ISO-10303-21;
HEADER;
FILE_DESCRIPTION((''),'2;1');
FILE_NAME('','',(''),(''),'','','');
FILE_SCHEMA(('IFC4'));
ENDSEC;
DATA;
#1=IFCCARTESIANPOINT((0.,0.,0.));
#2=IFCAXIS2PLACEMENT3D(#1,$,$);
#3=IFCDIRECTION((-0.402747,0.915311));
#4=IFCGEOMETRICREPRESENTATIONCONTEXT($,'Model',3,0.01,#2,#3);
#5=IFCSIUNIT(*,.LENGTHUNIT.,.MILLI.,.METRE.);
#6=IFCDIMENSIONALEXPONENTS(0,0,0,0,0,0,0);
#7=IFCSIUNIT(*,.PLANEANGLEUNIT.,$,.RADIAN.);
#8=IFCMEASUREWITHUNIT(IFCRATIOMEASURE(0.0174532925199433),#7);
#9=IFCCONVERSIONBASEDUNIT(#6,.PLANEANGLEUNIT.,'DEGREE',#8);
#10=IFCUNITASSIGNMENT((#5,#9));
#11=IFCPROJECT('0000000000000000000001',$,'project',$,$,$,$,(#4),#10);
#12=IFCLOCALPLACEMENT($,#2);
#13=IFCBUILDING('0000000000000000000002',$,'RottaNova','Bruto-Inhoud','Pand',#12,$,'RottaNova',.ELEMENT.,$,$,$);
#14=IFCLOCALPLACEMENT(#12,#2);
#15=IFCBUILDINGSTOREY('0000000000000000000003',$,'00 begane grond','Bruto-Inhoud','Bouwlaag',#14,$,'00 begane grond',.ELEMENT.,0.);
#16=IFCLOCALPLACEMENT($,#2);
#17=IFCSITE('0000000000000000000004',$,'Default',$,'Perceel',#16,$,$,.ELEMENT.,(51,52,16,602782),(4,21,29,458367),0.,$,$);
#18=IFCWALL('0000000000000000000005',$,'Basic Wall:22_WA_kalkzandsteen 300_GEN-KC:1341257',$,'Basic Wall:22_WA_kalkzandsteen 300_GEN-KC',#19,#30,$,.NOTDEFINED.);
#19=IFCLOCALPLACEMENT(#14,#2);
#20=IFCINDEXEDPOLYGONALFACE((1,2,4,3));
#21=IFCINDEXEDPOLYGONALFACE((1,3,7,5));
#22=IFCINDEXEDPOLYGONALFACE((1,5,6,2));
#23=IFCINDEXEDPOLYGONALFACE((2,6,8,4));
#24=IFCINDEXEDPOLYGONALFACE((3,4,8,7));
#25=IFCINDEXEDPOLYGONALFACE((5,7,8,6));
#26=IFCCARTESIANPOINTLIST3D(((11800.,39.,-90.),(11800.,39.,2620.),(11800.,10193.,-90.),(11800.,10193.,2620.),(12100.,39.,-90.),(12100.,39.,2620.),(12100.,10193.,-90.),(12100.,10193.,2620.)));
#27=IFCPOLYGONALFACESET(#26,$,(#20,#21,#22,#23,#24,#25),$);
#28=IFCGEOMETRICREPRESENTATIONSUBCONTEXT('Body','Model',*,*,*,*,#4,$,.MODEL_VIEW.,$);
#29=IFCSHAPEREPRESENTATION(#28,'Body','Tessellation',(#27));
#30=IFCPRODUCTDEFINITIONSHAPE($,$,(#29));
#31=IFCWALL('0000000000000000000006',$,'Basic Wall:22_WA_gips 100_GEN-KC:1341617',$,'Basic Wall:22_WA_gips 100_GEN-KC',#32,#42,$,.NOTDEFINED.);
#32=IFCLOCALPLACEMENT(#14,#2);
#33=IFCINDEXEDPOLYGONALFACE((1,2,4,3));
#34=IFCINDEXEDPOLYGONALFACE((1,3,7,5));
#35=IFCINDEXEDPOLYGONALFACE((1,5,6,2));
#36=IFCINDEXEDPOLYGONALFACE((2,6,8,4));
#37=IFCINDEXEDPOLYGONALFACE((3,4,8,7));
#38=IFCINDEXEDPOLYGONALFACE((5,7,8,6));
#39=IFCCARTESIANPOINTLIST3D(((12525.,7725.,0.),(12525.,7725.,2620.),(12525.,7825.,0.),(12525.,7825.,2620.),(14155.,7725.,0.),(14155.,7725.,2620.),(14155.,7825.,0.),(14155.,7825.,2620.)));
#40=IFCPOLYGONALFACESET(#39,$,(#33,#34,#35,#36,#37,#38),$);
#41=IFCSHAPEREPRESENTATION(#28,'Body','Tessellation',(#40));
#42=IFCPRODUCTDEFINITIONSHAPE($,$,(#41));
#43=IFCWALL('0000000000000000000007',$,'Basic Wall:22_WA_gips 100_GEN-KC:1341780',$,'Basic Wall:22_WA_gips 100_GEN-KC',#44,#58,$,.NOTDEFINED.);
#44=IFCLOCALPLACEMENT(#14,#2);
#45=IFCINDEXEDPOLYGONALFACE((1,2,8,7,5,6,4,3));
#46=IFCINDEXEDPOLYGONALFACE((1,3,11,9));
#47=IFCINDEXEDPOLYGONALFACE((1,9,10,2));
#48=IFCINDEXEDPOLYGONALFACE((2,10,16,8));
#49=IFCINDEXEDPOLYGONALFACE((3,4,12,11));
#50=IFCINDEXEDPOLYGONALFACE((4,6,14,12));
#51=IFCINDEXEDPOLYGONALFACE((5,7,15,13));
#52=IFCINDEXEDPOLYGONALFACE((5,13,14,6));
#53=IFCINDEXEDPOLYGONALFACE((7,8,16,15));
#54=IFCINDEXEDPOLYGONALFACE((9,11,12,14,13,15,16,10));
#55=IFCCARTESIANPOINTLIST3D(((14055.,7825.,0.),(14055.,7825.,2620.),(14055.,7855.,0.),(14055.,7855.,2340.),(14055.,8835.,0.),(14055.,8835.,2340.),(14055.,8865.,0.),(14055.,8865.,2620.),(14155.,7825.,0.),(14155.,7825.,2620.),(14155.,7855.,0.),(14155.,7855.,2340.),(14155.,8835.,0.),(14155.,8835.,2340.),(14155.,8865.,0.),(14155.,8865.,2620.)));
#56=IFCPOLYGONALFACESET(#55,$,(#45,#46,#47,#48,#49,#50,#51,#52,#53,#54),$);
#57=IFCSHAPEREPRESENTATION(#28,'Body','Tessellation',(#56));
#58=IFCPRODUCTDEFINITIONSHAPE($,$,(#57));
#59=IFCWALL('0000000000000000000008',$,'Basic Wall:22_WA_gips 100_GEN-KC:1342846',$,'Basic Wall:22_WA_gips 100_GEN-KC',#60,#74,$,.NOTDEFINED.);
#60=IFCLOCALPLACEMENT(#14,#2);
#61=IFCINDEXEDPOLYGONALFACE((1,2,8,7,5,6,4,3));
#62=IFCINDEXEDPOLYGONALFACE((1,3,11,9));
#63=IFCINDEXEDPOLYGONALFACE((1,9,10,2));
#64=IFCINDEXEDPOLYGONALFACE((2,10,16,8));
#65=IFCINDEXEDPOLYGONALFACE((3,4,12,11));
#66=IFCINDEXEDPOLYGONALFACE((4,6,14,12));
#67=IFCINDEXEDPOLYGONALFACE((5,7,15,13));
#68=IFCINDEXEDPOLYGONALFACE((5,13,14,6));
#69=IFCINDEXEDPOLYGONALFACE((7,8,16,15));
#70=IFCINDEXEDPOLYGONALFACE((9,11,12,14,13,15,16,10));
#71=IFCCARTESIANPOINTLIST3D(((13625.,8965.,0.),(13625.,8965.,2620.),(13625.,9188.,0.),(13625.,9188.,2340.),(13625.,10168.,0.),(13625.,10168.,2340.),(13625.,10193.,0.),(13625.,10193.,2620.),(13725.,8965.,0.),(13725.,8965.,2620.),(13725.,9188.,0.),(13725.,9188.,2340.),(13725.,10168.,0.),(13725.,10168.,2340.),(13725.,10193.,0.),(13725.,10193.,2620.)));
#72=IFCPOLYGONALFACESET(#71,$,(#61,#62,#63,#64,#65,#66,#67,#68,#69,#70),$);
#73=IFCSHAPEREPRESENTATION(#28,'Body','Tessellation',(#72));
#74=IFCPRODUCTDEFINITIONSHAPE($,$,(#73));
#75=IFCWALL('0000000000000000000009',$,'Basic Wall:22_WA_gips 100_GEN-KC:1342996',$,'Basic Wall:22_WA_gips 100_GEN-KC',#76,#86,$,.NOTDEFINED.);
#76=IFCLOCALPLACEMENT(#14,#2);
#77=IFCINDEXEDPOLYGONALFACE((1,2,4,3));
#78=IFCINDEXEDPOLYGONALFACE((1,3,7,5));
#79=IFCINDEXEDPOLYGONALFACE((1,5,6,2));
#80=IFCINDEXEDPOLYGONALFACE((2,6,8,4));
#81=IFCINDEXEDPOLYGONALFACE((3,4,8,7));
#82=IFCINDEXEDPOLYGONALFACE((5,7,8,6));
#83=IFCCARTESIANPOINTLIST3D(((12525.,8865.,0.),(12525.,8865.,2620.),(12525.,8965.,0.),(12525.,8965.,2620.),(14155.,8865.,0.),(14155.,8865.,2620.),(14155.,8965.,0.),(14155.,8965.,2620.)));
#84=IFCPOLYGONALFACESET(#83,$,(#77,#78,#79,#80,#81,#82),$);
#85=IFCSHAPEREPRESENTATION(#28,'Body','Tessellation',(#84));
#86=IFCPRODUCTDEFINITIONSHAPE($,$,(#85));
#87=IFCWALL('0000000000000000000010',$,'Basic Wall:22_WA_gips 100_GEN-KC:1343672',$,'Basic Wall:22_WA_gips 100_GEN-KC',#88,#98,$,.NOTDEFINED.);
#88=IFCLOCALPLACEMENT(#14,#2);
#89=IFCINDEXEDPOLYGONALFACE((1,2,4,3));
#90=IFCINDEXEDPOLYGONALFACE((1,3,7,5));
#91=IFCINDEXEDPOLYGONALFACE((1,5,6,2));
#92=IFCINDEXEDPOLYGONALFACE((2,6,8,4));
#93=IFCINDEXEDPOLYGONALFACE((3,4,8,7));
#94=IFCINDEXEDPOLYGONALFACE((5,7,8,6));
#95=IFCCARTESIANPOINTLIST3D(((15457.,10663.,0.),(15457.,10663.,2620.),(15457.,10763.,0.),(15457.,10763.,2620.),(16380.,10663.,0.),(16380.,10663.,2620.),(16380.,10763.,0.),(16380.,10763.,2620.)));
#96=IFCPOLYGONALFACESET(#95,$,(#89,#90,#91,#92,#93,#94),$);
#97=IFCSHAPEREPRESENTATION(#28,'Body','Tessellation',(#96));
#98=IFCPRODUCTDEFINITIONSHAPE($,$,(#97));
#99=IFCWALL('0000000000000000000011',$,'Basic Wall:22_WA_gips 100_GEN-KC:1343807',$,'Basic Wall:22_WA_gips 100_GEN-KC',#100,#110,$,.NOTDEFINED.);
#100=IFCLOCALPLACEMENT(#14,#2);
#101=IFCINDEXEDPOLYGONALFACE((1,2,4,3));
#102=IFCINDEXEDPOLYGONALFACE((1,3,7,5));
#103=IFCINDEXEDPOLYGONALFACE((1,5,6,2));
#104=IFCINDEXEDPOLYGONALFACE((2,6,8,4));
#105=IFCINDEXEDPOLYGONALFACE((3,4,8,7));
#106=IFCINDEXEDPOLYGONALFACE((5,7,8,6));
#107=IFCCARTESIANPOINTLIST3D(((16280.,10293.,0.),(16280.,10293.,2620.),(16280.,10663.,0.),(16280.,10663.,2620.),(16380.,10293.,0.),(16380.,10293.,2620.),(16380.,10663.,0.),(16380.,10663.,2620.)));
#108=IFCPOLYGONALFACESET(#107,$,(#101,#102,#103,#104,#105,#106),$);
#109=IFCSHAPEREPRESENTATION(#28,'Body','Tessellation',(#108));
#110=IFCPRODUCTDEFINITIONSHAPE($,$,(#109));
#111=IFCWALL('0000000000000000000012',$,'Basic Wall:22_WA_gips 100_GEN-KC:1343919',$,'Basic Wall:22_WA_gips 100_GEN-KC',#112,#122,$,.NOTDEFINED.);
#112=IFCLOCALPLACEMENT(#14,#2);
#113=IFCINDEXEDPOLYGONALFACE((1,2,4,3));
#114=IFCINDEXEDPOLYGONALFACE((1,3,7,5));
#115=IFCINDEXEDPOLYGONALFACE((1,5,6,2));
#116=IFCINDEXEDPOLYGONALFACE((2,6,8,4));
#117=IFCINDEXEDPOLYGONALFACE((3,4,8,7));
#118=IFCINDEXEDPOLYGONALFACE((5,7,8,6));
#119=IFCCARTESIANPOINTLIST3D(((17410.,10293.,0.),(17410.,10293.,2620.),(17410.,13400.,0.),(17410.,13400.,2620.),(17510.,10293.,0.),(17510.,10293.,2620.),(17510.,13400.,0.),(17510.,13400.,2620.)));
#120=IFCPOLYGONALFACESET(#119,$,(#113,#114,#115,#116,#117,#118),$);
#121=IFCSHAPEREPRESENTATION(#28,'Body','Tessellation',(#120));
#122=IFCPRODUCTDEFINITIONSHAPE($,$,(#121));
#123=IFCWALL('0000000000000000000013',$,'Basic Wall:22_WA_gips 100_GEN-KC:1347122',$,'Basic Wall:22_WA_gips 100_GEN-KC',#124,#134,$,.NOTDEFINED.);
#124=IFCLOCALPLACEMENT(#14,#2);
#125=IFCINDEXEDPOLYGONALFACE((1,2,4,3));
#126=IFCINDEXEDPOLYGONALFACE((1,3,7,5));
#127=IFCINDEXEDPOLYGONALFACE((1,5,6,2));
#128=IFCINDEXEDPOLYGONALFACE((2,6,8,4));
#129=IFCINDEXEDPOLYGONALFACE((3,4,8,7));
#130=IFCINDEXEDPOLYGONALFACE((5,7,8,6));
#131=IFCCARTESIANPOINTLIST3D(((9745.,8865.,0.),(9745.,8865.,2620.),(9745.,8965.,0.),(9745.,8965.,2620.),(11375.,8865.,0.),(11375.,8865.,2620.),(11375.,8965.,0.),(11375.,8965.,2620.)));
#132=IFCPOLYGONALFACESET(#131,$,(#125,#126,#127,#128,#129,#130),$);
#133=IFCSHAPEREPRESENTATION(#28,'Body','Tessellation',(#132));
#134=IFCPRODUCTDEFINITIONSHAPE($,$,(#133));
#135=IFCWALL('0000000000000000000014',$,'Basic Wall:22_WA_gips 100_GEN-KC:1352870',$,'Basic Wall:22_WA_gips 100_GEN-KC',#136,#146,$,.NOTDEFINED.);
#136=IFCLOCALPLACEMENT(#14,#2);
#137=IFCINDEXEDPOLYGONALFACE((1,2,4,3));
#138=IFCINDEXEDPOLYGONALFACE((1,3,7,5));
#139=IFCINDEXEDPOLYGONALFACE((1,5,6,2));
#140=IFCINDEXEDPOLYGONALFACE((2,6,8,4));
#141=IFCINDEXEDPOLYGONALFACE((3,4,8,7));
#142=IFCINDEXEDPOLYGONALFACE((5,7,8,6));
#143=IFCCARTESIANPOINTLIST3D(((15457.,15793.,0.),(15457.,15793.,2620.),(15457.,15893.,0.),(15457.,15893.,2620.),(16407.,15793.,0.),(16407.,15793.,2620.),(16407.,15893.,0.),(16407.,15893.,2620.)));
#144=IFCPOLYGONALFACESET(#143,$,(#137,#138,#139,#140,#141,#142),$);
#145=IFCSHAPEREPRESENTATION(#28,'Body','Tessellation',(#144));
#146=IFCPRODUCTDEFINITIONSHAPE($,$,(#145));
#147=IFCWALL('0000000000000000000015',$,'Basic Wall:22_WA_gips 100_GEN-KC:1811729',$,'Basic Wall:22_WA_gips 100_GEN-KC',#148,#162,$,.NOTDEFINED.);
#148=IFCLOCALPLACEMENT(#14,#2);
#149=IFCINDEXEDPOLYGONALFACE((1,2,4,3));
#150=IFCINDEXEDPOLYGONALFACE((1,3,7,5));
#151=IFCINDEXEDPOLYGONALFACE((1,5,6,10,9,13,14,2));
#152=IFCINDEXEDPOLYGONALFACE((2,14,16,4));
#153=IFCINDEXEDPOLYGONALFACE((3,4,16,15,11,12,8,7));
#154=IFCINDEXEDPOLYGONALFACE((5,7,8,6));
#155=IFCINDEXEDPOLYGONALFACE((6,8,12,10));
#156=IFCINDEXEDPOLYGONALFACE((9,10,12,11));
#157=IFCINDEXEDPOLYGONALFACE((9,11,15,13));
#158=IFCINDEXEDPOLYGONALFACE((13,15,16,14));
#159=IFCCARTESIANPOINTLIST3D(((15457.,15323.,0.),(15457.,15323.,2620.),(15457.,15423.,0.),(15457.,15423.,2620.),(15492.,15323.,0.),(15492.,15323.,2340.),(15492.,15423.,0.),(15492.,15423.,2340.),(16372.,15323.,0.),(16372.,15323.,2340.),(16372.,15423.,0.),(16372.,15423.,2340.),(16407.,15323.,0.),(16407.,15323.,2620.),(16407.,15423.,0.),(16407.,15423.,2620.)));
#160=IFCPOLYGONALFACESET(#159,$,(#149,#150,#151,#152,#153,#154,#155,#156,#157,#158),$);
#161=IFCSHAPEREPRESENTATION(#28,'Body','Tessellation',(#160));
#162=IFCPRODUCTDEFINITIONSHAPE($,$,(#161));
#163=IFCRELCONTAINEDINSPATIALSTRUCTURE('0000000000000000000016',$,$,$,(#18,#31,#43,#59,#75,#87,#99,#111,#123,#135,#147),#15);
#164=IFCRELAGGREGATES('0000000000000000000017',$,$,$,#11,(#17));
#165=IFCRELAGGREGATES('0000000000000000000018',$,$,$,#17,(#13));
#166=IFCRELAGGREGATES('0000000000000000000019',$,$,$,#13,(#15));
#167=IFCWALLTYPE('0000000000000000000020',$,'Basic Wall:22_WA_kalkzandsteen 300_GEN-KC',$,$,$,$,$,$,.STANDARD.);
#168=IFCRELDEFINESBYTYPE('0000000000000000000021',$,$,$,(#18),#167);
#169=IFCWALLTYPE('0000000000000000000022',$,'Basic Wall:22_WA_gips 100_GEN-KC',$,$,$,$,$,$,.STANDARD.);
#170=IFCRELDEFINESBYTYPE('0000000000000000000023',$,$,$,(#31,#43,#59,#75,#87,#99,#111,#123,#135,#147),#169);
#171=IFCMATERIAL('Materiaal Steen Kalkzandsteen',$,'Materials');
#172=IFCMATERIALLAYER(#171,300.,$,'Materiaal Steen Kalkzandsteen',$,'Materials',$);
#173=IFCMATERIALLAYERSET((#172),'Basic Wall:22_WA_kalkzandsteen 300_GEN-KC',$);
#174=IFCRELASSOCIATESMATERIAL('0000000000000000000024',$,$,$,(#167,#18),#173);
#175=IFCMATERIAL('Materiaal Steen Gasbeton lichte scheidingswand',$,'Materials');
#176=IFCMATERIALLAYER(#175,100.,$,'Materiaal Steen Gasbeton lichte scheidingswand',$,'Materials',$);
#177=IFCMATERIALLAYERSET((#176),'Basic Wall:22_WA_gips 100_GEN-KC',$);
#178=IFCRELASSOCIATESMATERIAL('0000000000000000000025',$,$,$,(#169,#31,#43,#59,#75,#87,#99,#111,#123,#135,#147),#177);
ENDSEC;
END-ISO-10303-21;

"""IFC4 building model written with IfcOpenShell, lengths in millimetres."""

from ifc_helpers import new_model, entity, si_unit, converted_unit, direction, frame, frame_2d, origin, place, context, subcontext, project, spatial, rectangle, extrude, material, layer, layer_set, type_object, element, save


model = new_model("IFC4")

# Units and contexts
model_context = context("Model", 3, precision=0.01, world=origin(), true_north=direction((-0.402747, 0.915311)))
body_context = subcontext(model_context, "Body", "Model", "MODEL_VIEW")
ifc_project = project(units=[si_unit("LENGTHUNIT", "METRE", prefix="MILLI"), converted_unit("PLANEANGLEUNIT", "DEGREE", entity("IfcRatioMeasure", 0.0174532925199433), si_unit("PLANEANGLEUNIT", "RADIAN"), dimensions=[0, 0, 0, 0, 0, 0, 0])], contexts=[model_context])

# Site, building, storey
site_placement = place(None, origin())
site = spatial("IfcSite", under=ifc_project, at=site_placement, Name="Default", ObjectType="Perceel", CompositionType="ELEMENT", RefLatitude=(51, 52, 16, 602782), RefLongitude=(4, 21, 29, 458367), RefElevation=0.0)
building_placement = place(None, origin())
building = spatial("IfcBuilding", under=site, at=building_placement, Name="RottaNova", Description="Bruto-Inhoud", ObjectType="Pand", LongName="RottaNova", CompositionType="ELEMENT")
storey_placement = place(building_placement, origin())
storey = spatial("IfcBuildingStorey", under=building, at=storey_placement, Name="00 begane grond", Description="Bruto-Inhoud", ObjectType="Bouwlaag", LongName="00 begane grond", CompositionType="ELEMENT", Elevation=0.0)

# Walls
ifc_material_1 = material(Name="Materiaal Steen Kalkzandsteen", Category="Materials")
ifc_layer_1 = layer(ifc_material_1, 300.0, Name="Materiaal Steen Kalkzandsteen", Category="Materials")
ifc_layer_set_1 = layer_set([ifc_layer_1], Name="Basic Wall:22_WA_kalkzandsteen 300_GEN-KC")
wall_type_1 = type_object("IfcWallType", Name="Basic Wall:22_WA_kalkzandsteen 300_GEN-KC", PredefinedType="STANDARD", material=ifc_layer_set_1)
wall_1_placement = place(storey_placement, frame((11950.0, 39.0, -90.0), z_axis=(0.0, 0.0, 1.0), x_axis=(0.0, 1.0, 0.0)))
element("IfcWall", 1, at=wall_1_placement, inside=storey, type_object=wall_type_1, material=ifc_layer_set_1, Name="Basic Wall:22_WA_kalkzandsteen 300_GEN-KC:1341257", ObjectType="Basic Wall:22_WA_kalkzandsteen 300_GEN-KC", PredefinedType="NOTDEFINED", context=body_context, shape_type="SweptSolid", body=[
    extrude(rectangle(XDim=10154.0, YDim=300.0, at=frame_2d((5077.0, 0.0), x_axis=(-1.0, 0.0))), origin(), (0.0, 0.0, 1.0), 2710.0),
])
ifc_material_2 = material(Name="Materiaal Steen Gasbeton lichte scheidingswand", Category="Materials")
ifc_layer_2 = layer(ifc_material_2, 100.0, Name="Materiaal Steen Gasbeton lichte scheidingswand", Category="Materials")
ifc_layer_set_2 = layer_set([ifc_layer_2], Name="Basic Wall:22_WA_gips 100_GEN-KC")
wall_type_2 = type_object("IfcWallType", Name="Basic Wall:22_WA_gips 100_GEN-KC", PredefinedType="STANDARD", material=ifc_layer_set_2)
wall_2_placement = place(storey_placement, frame((14155.0, 7775.0, 0.0), z_axis=(0.0, 0.0, 1.0), x_axis=(-1.0, 0.0, 0.0)))
element("IfcWall", 2, at=wall_2_placement, inside=storey, type_object=wall_type_2, material=ifc_layer_set_2, Name="Basic Wall:22_WA_gips 100_GEN-KC:1341617", ObjectType="Basic Wall:22_WA_gips 100_GEN-KC", PredefinedType="NOTDEFINED", context=body_context, shape_type="SweptSolid", body=[
    extrude(rectangle(XDim=1630.0, YDim=100.0, at=frame_2d((815.0, 0.0), x_axis=(-1.0, 0.0))), origin(), (0.0, 0.0, 1.0), 2620.0),
])

# Walls, openings
wall_3_placement = place(storey_placement, frame((14105.0, 8865.0, 0.0), z_axis=(0.0, 0.0, 1.0), x_axis=(0.0, -1.0, 0.0)))
wall_3 = element("IfcWall", 3, at=wall_3_placement, inside=storey, type_object=wall_type_2, material=ifc_layer_set_2, Name="Basic Wall:22_WA_gips 100_GEN-KC:1341780", ObjectType="Basic Wall:22_WA_gips 100_GEN-KC", PredefinedType="NOTDEFINED", context=body_context, shape_type="SweptSolid", body=[
    extrude(rectangle(XDim=1040.0, YDim=100.0, at=frame_2d((520.0, 0.0), x_axis=(-1.0, 0.0))), origin(), (0.0, 0.0, 1.0), 2620.0),
])
opening_1_placement = place(wall_3_placement, frame((30.0, -50.0, -90.0)))
element("IfcOpeningElement", 4, at=opening_1_placement, cuts=wall_3, PredefinedType="OPENING", context=body_context, shape_type="SweptSolid", body=[
    extrude(rectangle(XDim=2430.0, YDim=980.0, at=frame_2d((1215.0, 490.0), x_axis=(1.0, 0.0))), frame((0.0, 0.0, 0.0), z_axis=(0.0, 1.0, 0.0), x_axis=(0.0, 0.0, 1.0)), (0.0, 0.0, 1.0), 100.0),
])
wall_4_placement = place(storey_placement, frame((13675.0, 8965.0, 0.0), z_axis=(0.0, 0.0, 1.0), x_axis=(0.0, 1.0, 0.0)))
wall_4 = element("IfcWall", 5, at=wall_4_placement, inside=storey, type_object=wall_type_2, material=ifc_layer_set_2, Name="Basic Wall:22_WA_gips 100_GEN-KC:1342846", ObjectType="Basic Wall:22_WA_gips 100_GEN-KC", PredefinedType="NOTDEFINED", context=body_context, shape_type="SweptSolid", body=[
    extrude(rectangle(XDim=1228.0, YDim=100.0, at=frame_2d((614.0, 0.0), x_axis=(1.0, 0.0))), origin(), (0.0, 0.0, 1.0), 2620.0),
])
opening_2_placement = place(wall_4_placement, frame((1203.0, 50.0, -90.0)))
element("IfcOpeningElement", 6, at=opening_2_placement, cuts=wall_4, PredefinedType="OPENING", context=body_context, shape_type="SweptSolid", body=[
    extrude(rectangle(XDim=2430.0, YDim=980.0, at=frame_2d((1215.0, 490.0), x_axis=(1.0, 0.0))), frame((0.0, 0.0, 0.0), z_axis=(0.0, -1.0, 0.0), x_axis=(0.0, 0.0, 1.0)), (0.0, 0.0, 1.0), 100.0),
])

# Walls
wall_5_placement = place(storey_placement, frame((12525.0, 8915.0, 0.0)))
element("IfcWall", 7, at=wall_5_placement, inside=storey, type_object=wall_type_2, material=ifc_layer_set_2, Name="Basic Wall:22_WA_gips 100_GEN-KC:1342996", ObjectType="Basic Wall:22_WA_gips 100_GEN-KC", PredefinedType="NOTDEFINED", context=body_context, shape_type="SweptSolid", body=[
    extrude(rectangle(XDim=1630.0, YDim=100.0, at=frame_2d((815.0, 0.0), x_axis=(-1.0, 0.0))), origin(), (0.0, 0.0, 1.0), 2620.0),
])
wall_6_placement = place(storey_placement, frame((16380.0, 10713.0, 0.0), z_axis=(0.0, 0.0, 1.0), x_axis=(-1.0, 0.0, 0.0)))
element("IfcWall", 8, at=wall_6_placement, inside=storey, type_object=wall_type_2, material=ifc_layer_set_2, Name="Basic Wall:22_WA_gips 100_GEN-KC:1343672", ObjectType="Basic Wall:22_WA_gips 100_GEN-KC", PredefinedType="NOTDEFINED", context=body_context, shape_type="SweptSolid", body=[
    extrude(rectangle(XDim=923.0, YDim=100.0, at=frame_2d((461.5, 0.0), x_axis=(-1.0, 0.0))), origin(), (0.0, 0.0, 1.0), 2620.0),
])
wall_7_placement = place(storey_placement, frame((16330.0, 10663.0, 0.0), z_axis=(0.0, 0.0, 1.0), x_axis=(0.0, -1.0, 0.0)))
element("IfcWall", 9, at=wall_7_placement, inside=storey, type_object=wall_type_2, material=ifc_layer_set_2, Name="Basic Wall:22_WA_gips 100_GEN-KC:1343807", ObjectType="Basic Wall:22_WA_gips 100_GEN-KC", PredefinedType="NOTDEFINED", context=body_context, shape_type="SweptSolid", body=[
    extrude(rectangle(XDim=370.0, YDim=100.0, at=frame_2d((185.0, 0.0), x_axis=(-1.0, 0.0))), origin(), (0.0, 0.0, 1.0), 2620.0),
])
wall_8_placement = place(storey_placement, frame((17460.0, 13400.0, 0.0), z_axis=(0.0, 0.0, 1.0), x_axis=(0.0, -1.0, 0.0)))
element("IfcWall", 10, at=wall_8_placement, inside=storey, type_object=wall_type_2, material=ifc_layer_set_2, Name="Basic Wall:22_WA_gips 100_GEN-KC:1343919", ObjectType="Basic Wall:22_WA_gips 100_GEN-KC", PredefinedType="NOTDEFINED", context=body_context, shape_type="SweptSolid", body=[
    extrude(rectangle(XDim=3107.0, YDim=100.0, at=frame_2d((1553.5, 0.0), x_axis=(-1.0, 0.0))), origin(), (0.0, 0.0, 1.0), 2620.0),
])
wall_9_placement = place(storey_placement, frame((11375.0, 8915.0, 0.0), z_axis=(0.0, 0.0, 1.0), x_axis=(-1.0, 0.0, 0.0)))
element("IfcWall", 11, at=wall_9_placement, inside=storey, type_object=wall_type_2, material=ifc_layer_set_2, Name="Basic Wall:22_WA_gips 100_GEN-KC:1347122", ObjectType="Basic Wall:22_WA_gips 100_GEN-KC", PredefinedType="NOTDEFINED", context=body_context, shape_type="SweptSolid", body=[
    extrude(rectangle(XDim=1630.0, YDim=100.0, at=frame_2d((815.0, 0.0), x_axis=(-1.0, 0.0))), origin(), (0.0, 0.0, 1.0), 2620.0),
])
wall_10_placement = place(storey_placement, frame((16407.0, 15843.0, 0.0), z_axis=(0.0, 0.0, 1.0), x_axis=(-1.0, 0.0, 0.0)))
element("IfcWall", 12, at=wall_10_placement, inside=storey, type_object=wall_type_2, material=ifc_layer_set_2, Name="Basic Wall:22_WA_gips 100_GEN-KC:1352870", ObjectType="Basic Wall:22_WA_gips 100_GEN-KC", PredefinedType="NOTDEFINED", context=body_context, shape_type="SweptSolid", body=[
    extrude(rectangle(XDim=950.0, YDim=100.0, at=frame_2d((475.0, 0.0), x_axis=(-1.0, 0.0))), origin(), (0.0, 0.0, 1.0), 2620.0),
])

# Wall, opening
wall_11_placement = place(storey_placement, frame((16407.0, 15373.0, 0.0), z_axis=(0.0, 0.0, 1.0), x_axis=(-1.0, 0.0, 0.0)))
wall_11 = element("IfcWall", 13, at=wall_11_placement, inside=storey, type_object=wall_type_2, material=ifc_layer_set_2, Name="Basic Wall:22_WA_gips 100_GEN-KC:1811729", ObjectType="Basic Wall:22_WA_gips 100_GEN-KC", PredefinedType="NOTDEFINED", context=body_context, shape_type="SweptSolid", body=[
    extrude(rectangle(XDim=950.0, YDim=100.0, at=frame_2d((475.0, 0.0), x_axis=(1.0, 0.0))), origin(), (0.0, 0.0, 1.0), 2620.0),
])
opening_3_placement = place(wall_11_placement, frame((35.0, -50.0, -70.0)))
element("IfcOpeningElement", 14, at=opening_3_placement, cuts=wall_11, PredefinedType="OPENING", context=body_context, shape_type="SweptSolid", body=[
    extrude(rectangle(XDim=2410.0, YDim=880.0, at=frame_2d((1205.0, 440.0), x_axis=(1.0, 0.0))), frame((0.0, 0.0, 0.0), z_axis=(0.0, 1.0, 0.0), x_axis=(0.0, 0.0, 1.0)), (0.0, 0.0, 1.0), 100.0),
])

save(model, "model.ifc")
